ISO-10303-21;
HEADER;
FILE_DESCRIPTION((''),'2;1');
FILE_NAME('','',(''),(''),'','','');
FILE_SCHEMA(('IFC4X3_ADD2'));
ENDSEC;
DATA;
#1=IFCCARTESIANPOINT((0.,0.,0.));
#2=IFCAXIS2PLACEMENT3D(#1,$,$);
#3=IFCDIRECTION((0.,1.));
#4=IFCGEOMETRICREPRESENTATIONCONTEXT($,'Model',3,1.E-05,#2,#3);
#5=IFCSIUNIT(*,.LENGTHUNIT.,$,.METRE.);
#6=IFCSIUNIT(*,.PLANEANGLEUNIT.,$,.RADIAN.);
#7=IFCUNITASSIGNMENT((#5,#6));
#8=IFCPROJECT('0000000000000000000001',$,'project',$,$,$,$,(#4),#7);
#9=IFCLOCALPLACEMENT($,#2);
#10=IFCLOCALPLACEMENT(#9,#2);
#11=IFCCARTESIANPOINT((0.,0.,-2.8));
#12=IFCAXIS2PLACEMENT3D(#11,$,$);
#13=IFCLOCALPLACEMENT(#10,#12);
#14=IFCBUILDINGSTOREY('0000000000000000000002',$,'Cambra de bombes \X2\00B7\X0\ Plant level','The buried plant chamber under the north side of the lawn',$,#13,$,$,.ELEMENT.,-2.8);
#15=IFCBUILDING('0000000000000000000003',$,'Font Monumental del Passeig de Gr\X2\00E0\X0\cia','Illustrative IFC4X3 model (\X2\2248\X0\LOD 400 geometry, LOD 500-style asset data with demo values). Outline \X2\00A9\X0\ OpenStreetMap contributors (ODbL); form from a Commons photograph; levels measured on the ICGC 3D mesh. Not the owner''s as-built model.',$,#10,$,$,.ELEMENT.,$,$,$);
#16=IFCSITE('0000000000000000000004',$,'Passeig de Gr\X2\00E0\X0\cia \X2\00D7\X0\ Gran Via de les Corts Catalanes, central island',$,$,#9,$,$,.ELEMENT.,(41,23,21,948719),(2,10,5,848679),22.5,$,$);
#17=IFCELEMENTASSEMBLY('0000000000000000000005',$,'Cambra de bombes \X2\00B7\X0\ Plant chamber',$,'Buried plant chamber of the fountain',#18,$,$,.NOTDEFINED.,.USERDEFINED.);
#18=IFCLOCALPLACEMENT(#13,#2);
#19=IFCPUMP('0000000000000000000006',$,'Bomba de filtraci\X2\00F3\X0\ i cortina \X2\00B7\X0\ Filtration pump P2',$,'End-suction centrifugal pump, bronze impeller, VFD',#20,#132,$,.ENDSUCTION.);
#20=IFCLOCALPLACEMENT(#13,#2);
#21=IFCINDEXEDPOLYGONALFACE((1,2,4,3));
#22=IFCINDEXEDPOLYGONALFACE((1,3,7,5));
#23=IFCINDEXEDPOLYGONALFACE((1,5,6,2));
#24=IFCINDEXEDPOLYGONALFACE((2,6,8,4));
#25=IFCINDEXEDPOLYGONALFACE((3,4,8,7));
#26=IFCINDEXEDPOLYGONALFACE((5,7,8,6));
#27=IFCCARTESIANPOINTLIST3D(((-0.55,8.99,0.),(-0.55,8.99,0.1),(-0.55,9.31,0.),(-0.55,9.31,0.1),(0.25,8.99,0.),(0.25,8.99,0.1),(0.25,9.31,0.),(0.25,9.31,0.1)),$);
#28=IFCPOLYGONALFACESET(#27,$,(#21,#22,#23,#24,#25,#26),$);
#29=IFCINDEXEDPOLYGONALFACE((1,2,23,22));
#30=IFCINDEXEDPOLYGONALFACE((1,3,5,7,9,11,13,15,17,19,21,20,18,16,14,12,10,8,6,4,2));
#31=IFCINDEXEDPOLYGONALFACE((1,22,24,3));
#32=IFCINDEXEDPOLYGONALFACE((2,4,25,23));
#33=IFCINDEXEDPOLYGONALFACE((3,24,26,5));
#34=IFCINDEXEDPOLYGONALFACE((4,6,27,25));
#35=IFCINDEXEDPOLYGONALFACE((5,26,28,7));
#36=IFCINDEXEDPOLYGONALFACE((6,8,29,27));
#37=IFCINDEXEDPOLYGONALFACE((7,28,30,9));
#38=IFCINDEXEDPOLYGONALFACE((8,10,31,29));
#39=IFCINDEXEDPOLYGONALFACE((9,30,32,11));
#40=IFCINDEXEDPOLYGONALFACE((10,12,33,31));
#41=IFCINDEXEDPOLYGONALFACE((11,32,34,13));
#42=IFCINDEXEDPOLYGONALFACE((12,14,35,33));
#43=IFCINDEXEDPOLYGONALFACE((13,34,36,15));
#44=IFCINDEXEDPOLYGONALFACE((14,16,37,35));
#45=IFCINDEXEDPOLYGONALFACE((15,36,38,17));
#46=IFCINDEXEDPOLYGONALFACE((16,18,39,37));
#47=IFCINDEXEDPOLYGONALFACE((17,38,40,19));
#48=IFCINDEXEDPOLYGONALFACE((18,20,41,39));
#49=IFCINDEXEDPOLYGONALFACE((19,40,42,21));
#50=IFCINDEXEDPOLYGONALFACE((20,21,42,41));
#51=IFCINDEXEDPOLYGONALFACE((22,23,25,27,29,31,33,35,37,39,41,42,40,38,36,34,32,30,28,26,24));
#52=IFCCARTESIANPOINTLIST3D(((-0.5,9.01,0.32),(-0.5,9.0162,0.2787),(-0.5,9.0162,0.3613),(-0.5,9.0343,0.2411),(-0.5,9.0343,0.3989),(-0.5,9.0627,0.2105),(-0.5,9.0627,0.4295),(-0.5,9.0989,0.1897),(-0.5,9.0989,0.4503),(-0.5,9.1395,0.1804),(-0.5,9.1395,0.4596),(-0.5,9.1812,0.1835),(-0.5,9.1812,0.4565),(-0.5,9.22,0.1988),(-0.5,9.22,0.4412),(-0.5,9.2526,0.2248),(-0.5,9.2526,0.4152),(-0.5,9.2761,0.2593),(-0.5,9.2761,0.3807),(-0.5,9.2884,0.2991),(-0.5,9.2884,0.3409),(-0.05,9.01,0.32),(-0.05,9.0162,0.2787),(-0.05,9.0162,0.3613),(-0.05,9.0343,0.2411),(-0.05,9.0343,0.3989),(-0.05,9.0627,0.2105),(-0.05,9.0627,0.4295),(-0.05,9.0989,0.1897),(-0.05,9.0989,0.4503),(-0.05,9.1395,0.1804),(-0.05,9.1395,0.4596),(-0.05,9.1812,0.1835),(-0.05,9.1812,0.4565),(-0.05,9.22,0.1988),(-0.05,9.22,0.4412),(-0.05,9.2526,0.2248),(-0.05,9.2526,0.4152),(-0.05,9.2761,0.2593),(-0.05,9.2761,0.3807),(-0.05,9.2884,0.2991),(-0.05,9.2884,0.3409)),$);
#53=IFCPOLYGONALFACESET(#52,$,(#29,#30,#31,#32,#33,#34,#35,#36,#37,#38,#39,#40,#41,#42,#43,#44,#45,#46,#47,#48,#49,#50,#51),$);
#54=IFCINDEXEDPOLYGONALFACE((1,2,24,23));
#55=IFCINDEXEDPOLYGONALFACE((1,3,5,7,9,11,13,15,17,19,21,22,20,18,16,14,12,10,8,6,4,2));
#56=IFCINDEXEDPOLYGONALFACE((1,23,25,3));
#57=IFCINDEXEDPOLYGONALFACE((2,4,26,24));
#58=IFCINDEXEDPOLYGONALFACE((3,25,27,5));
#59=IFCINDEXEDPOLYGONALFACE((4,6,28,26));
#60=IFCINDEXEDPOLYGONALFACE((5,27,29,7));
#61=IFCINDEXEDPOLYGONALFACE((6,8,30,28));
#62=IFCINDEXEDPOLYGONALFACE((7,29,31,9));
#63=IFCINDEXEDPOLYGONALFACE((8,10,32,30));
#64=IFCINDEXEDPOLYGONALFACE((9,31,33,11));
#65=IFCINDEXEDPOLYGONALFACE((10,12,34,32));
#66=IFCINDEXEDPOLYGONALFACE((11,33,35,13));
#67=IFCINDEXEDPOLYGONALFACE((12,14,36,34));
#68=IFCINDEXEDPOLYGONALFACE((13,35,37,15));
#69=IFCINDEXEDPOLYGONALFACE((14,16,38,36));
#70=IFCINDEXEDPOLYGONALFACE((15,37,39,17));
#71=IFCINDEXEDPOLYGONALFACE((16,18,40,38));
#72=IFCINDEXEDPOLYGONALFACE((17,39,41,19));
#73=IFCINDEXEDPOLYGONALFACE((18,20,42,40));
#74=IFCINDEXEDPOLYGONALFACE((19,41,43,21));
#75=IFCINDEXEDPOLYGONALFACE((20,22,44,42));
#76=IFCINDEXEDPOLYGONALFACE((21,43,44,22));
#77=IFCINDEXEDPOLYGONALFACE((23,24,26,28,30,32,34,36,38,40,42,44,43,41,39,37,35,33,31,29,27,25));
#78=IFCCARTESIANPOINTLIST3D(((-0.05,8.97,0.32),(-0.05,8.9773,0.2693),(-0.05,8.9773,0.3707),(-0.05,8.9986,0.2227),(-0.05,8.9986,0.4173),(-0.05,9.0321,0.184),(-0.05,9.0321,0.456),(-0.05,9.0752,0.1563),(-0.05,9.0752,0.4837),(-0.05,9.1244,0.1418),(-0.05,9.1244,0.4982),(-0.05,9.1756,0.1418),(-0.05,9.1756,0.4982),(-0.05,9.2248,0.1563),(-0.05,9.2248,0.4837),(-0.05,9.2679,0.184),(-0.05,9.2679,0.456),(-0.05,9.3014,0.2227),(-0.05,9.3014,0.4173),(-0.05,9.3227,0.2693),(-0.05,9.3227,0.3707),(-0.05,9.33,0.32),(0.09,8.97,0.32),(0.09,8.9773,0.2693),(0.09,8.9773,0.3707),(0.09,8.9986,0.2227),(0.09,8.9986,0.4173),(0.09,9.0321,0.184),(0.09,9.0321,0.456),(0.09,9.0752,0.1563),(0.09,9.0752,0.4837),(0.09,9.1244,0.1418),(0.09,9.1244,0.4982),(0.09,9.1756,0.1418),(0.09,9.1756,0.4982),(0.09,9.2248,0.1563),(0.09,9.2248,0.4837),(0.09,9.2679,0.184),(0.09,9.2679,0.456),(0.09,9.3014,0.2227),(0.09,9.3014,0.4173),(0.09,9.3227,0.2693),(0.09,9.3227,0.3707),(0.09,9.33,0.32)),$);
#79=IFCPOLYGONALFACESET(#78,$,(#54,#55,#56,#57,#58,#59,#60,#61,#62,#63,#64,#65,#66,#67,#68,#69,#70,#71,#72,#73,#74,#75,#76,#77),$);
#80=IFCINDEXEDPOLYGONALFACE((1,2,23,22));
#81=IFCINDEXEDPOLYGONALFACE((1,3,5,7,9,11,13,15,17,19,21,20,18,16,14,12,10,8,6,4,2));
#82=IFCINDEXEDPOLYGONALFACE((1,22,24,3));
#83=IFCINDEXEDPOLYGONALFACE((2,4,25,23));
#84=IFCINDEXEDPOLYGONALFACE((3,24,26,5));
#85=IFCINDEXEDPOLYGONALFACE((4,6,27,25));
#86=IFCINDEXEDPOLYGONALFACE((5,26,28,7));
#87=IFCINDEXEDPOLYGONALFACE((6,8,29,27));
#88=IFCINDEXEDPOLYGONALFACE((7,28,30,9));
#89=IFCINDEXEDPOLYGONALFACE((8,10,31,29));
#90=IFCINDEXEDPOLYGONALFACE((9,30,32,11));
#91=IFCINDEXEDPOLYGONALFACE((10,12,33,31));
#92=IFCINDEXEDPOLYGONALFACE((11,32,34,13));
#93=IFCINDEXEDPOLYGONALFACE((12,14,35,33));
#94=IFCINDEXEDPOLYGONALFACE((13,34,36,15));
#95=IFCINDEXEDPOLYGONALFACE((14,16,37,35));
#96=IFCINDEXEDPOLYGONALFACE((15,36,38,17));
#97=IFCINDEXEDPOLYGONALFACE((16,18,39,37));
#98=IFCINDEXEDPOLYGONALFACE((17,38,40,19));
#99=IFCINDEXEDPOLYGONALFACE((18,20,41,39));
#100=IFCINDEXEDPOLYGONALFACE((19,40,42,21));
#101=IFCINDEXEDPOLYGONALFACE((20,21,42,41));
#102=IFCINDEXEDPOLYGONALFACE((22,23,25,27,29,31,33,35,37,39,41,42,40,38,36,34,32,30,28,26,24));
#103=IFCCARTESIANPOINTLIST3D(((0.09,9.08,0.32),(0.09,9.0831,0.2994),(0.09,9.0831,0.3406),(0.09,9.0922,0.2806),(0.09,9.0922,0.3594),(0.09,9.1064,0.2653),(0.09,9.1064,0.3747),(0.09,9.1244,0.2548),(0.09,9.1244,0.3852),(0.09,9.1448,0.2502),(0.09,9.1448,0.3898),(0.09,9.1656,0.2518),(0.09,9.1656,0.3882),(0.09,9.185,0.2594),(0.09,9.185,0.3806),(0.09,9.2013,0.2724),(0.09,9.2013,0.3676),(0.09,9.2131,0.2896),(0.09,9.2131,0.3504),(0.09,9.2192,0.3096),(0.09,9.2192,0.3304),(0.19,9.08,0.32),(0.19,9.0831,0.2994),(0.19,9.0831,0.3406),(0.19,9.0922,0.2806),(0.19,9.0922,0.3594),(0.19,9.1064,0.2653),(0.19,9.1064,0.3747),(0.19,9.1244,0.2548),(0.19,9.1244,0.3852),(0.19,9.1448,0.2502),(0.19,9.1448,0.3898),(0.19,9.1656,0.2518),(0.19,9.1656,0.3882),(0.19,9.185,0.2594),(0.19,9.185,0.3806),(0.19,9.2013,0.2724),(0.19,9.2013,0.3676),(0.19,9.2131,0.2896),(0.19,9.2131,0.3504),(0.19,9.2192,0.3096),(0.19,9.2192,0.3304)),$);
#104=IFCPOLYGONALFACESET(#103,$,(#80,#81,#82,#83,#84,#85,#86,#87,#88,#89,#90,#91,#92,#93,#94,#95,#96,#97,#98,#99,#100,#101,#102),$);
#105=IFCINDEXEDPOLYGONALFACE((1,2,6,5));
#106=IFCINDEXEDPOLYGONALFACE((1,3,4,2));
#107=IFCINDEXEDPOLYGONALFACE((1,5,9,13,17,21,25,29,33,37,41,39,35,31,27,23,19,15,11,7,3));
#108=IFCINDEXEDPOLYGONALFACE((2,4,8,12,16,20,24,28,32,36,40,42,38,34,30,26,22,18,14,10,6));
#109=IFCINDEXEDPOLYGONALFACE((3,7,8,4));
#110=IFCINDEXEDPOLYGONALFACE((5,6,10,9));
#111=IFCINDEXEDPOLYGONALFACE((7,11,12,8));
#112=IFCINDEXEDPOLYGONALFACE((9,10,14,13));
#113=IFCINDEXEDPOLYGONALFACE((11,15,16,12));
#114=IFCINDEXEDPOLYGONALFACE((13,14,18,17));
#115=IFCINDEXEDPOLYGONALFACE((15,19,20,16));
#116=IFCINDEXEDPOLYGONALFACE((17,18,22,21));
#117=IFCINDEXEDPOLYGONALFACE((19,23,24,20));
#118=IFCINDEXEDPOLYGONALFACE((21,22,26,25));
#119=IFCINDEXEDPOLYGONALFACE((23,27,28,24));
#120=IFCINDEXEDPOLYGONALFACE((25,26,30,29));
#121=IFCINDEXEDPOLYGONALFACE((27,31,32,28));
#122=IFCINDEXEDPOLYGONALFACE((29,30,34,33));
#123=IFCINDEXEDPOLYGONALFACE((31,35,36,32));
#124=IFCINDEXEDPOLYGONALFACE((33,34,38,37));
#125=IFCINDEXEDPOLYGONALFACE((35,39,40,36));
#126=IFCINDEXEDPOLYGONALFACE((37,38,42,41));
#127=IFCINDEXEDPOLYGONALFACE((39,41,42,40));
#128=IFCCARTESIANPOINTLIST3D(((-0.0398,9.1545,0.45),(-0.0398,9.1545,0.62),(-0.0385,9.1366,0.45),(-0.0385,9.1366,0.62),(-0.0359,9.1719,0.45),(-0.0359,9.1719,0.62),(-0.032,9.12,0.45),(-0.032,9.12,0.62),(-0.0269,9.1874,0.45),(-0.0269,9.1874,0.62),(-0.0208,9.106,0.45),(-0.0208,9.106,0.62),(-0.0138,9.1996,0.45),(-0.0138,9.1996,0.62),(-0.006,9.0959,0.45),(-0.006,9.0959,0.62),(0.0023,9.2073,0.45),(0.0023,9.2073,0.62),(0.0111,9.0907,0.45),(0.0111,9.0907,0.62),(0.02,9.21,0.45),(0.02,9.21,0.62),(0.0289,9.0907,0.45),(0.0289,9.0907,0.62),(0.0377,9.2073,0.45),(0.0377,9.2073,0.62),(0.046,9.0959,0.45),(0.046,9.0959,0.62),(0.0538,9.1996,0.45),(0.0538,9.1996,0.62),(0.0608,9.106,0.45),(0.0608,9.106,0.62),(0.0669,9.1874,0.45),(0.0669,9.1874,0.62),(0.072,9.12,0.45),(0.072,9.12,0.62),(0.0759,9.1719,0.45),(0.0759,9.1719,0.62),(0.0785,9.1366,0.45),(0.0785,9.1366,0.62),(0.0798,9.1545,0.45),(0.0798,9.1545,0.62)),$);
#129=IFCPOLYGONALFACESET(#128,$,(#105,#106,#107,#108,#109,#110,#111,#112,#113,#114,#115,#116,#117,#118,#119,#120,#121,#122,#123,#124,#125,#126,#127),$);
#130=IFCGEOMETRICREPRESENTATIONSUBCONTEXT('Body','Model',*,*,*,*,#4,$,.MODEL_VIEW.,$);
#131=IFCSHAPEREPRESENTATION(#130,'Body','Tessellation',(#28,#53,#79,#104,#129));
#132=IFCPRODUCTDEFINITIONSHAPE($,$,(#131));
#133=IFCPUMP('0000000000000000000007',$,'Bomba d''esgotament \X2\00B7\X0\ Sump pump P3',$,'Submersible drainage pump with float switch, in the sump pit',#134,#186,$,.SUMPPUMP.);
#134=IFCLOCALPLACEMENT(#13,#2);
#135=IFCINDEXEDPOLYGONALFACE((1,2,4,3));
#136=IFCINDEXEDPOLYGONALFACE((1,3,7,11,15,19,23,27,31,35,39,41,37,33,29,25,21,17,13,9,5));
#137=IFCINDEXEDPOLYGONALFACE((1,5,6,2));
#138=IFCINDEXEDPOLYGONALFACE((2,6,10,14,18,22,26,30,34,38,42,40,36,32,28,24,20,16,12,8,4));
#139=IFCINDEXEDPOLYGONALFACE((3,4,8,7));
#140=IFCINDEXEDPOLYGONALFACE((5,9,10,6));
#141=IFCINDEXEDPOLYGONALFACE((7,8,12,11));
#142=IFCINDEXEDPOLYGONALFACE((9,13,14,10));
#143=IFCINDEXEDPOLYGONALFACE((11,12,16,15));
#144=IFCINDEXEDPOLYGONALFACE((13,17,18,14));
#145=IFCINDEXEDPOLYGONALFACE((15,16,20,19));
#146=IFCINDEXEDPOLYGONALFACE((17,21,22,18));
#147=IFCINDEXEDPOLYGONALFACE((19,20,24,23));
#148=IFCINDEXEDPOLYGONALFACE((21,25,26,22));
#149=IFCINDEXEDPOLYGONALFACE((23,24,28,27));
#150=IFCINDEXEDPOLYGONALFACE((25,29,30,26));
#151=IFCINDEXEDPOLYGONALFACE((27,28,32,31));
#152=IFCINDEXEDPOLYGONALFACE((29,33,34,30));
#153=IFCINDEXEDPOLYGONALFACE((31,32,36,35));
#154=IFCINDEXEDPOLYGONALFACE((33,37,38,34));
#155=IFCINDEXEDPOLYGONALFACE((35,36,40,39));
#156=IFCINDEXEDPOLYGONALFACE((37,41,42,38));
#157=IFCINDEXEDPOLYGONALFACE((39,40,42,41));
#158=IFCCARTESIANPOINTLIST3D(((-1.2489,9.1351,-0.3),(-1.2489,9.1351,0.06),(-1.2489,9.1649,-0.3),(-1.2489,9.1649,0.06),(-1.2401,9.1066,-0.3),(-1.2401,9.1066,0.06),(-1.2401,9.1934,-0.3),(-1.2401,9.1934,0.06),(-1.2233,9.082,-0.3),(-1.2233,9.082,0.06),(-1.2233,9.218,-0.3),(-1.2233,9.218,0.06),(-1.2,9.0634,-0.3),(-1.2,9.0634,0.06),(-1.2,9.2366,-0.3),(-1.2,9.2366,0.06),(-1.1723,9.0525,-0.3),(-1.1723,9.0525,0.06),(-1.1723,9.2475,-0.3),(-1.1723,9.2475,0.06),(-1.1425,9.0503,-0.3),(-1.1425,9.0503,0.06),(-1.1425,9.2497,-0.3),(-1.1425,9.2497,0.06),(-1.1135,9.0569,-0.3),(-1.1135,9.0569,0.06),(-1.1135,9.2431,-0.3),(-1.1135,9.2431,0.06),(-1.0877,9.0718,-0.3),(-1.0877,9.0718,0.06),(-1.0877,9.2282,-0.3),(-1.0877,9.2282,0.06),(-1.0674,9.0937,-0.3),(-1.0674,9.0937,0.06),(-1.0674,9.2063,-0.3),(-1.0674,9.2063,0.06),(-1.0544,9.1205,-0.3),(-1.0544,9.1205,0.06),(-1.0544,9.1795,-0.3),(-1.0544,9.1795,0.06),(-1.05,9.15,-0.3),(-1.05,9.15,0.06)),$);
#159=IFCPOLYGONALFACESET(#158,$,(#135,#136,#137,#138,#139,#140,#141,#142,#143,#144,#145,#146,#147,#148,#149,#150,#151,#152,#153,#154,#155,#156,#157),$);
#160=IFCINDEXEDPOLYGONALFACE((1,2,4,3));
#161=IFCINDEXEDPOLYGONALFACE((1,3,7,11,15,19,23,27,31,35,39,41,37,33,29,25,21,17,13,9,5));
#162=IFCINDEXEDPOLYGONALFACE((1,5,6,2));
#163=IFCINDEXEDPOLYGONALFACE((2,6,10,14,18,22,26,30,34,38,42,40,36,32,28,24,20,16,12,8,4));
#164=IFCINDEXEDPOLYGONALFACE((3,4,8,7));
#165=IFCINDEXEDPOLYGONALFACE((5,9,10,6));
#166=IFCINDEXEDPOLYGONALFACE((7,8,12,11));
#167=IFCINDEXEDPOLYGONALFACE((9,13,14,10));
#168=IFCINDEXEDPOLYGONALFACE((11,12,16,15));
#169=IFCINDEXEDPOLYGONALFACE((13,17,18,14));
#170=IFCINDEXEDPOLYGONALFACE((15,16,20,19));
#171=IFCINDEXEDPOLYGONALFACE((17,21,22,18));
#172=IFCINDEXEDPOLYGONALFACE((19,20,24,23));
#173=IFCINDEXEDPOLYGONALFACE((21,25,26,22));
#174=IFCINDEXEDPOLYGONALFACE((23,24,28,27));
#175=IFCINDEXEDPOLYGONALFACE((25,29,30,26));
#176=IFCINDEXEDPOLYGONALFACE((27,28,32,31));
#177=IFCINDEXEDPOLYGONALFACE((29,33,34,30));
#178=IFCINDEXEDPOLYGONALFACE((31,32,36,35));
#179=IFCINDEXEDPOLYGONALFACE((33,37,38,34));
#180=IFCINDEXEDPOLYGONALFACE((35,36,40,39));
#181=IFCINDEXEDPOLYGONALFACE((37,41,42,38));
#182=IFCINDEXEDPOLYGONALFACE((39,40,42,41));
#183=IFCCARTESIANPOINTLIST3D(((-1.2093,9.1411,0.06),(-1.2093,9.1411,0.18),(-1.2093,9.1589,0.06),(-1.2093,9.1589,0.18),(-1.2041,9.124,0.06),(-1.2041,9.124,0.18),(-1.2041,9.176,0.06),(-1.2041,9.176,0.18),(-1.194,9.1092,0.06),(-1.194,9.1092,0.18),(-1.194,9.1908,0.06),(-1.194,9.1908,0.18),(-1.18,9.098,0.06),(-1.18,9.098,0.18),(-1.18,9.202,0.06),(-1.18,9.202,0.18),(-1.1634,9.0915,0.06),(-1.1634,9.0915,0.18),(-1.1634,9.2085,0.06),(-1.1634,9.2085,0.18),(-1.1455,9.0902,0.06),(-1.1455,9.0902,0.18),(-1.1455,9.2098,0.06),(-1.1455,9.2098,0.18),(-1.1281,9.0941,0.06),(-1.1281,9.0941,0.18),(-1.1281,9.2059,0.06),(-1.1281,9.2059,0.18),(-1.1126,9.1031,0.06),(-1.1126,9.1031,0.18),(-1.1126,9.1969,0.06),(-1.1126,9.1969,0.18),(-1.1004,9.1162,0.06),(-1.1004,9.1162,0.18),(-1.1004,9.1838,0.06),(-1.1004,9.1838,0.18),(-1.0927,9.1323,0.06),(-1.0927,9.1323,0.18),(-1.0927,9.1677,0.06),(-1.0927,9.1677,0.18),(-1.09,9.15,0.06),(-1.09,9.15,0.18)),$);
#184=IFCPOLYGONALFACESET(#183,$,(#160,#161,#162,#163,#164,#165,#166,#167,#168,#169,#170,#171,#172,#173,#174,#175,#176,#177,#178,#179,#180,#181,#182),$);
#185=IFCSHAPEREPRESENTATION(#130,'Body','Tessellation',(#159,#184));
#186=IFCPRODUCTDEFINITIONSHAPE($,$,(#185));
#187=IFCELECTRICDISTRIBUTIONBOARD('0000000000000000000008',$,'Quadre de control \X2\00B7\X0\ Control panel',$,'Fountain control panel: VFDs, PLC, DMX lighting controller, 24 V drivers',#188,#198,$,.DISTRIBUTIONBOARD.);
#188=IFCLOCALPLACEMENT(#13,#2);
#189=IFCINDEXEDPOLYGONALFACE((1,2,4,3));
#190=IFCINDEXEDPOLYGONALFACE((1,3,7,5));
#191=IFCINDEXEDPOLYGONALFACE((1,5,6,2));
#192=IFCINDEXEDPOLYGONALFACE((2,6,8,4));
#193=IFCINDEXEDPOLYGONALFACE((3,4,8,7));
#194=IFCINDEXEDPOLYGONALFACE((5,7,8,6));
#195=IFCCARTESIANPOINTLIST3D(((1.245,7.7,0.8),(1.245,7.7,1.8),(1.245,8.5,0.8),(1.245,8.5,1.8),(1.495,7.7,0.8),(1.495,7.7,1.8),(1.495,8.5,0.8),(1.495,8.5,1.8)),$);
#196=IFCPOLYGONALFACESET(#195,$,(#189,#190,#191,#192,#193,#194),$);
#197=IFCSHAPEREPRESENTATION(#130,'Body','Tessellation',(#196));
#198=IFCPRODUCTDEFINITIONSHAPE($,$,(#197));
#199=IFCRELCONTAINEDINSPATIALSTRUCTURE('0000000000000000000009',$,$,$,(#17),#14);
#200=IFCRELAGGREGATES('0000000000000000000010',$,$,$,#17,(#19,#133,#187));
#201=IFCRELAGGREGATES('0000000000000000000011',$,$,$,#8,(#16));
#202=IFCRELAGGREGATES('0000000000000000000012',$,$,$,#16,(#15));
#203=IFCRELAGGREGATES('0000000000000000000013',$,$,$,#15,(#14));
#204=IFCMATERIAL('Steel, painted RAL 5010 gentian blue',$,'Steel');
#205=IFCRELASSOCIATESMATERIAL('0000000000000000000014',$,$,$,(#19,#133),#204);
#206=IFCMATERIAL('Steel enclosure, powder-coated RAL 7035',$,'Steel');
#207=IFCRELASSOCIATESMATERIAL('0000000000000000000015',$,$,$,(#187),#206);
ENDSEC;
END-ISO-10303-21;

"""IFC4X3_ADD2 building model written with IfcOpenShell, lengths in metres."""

from ifc_helpers import new_model, si_unit, direction, frame, origin, origin_2d_with_axis, place, context, subcontext, project, spatial, rectangle, circle, extrude, material, element, aggregate, save


model = new_model("IFC4X3_ADD2")

# Units and contexts
model_context = context("Model", 3, precision=1e-05, world=origin(), true_north=direction((0.0, 1.0)))
body_context = subcontext(model_context, "Body", "Model", "MODEL_VIEW")
ifc_project = project(units=[si_unit("LENGTHUNIT", "METRE"), si_unit("PLANEANGLEUNIT", "RADIAN")], contexts=[model_context])

# Site, building, storey
site_placement = place(None, origin())
site = spatial("IfcSite", under=ifc_project, at=site_placement, Name="Passeig de Gràcia × Gran Via de les Corts Catalanes, central island", CompositionType="ELEMENT", RefLatitude=(41, 23, 21, 948719), RefLongitude=(2, 10, 5, 848679), RefElevation=22.5)
building_placement = place(site_placement, origin())
building = spatial("IfcBuilding", under=site, at=building_placement, Name="Font Monumental del Passeig de Gràcia", Description="Illustrative IFC4X3 model (≈LOD 400 geometry, LOD 500-style asset data with demo values). Outline © OpenStreetMap contributors (ODbL); form from a Commons photograph; levels measured on the ICGC 3D mesh. Not the owner's as-built model.", CompositionType="ELEMENT")
storey_placement = place(building_placement, frame((0.0, 0.0, -2.8)))
storey = spatial("IfcBuildingStorey", under=building, at=storey_placement, Name="Cambra de bombes · Plant level", Description="The buried plant chamber under the north side of the lawn", CompositionType="ELEMENT", Elevation=-2.8)

# Element assembly, pumps, electric distribution board
assembly_1_placement = place(building_placement, origin())
assembly_1 = element("IfcElementAssembly", 1, at=assembly_1_placement, inside=storey, Name="Cambra de bombes · Plant chamber", ObjectType="Buried plant chamber of the fountain", AssemblyPlace="NOTDEFINED", PredefinedType="USERDEFINED")
ifc_material_1 = material(Name="Steel, painted RAL 5010 gentian blue", Category="Steel")
pump_1_placement = place(building_placement, origin())
pump_1 = element("IfcPump", 2, at=pump_1_placement, material=ifc_material_1, Name="Bomba de filtració i cortina · Filtration pump P2", ObjectType="End-suction centrifugal pump, bronze impeller, VFD", PredefinedType="ENDSUCTION", context=body_context, shape_type="SweptSolid", body=[
    extrude(rectangle(XDim=0.8, YDim=0.32, at=origin_2d_with_axis()), frame((-0.15, 9.15, -2.8)), (0.0, 0.0, 1.0), 0.1),
    extrude(circle(Radius=0.14, at=origin_2d_with_axis()), frame((-0.5, 9.15, -2.48), z_axis=(1.0, 0.0, 0.0), x_axis=(0.0, -1.0, 0.0)), (0.0, 0.0, 1.0), 0.45),
    extrude(circle(Radius=0.18, at=origin_2d_with_axis()), frame((-0.05, 9.15, -2.48), z_axis=(1.0, 0.0, 0.0), x_axis=(0.0, -1.0, 0.0)), (0.0, 0.0, 1.0), 0.14),
    extrude(circle(Radius=0.07, at=origin_2d_with_axis()), frame((0.09, 9.15, -2.48), z_axis=(1.0, 0.0, 0.0), x_axis=(0.0, -1.0, 0.0)), (0.0, 0.0, 1.0), 0.1),
    extrude(circle(Radius=0.06, at=origin_2d_with_axis()), frame((0.02, 9.15, -2.35), z_axis=(0.0, 0.0, 1.0), x_axis=(0.0, 1.0, 0.0)), (0.0, 0.0, 1.0), 0.17),
])
pump_2_placement = place(building_placement, origin())
pump_2 = element("IfcPump", 3, at=pump_2_placement, material=ifc_material_1, Name="Bomba d'esgotament · Sump pump P3", ObjectType="Submersible drainage pump with float switch, in the sump pit", PredefinedType="SUMPPUMP", context=body_context, shape_type="SweptSolid", body=[
    extrude(circle(Radius=0.1, at=origin_2d_with_axis()), frame((-1.15, 9.15, -3.1)), (0.0, 0.0, 1.0), 0.36),
    extrude(circle(Radius=0.06, at=origin_2d_with_axis()), frame((-1.15, 9.15, -2.74)), (0.0, 0.0, 1.0), 0.12),
])
ifc_material_2 = material(Name="Steel enclosure, powder-coated RAL 7035", Category="Steel")
electric_distribution_board_placement = place(building_placement, origin())
electric_distribution_board = element("IfcElectricDistributionBoard", 4, at=electric_distribution_board_placement, material=ifc_material_2, Name="Quadre de control · Control panel", ObjectType="Fountain control panel: VFDs, PLC, DMX lighting controller, 24 V drivers", PredefinedType="DISTRIBUTIONBOARD", context=body_context, shape_type="SweptSolid", body=[
    extrude(rectangle(XDim=0.25, YDim=0.8, at=origin_2d_with_axis()), frame((1.37, 8.1, -2.0)), (0.0, 0.0, 1.0), 1.0),
])
aggregate(assembly_1, [pump_1, pump_2, electric_distribution_board])

save(model, "model.ifc")
